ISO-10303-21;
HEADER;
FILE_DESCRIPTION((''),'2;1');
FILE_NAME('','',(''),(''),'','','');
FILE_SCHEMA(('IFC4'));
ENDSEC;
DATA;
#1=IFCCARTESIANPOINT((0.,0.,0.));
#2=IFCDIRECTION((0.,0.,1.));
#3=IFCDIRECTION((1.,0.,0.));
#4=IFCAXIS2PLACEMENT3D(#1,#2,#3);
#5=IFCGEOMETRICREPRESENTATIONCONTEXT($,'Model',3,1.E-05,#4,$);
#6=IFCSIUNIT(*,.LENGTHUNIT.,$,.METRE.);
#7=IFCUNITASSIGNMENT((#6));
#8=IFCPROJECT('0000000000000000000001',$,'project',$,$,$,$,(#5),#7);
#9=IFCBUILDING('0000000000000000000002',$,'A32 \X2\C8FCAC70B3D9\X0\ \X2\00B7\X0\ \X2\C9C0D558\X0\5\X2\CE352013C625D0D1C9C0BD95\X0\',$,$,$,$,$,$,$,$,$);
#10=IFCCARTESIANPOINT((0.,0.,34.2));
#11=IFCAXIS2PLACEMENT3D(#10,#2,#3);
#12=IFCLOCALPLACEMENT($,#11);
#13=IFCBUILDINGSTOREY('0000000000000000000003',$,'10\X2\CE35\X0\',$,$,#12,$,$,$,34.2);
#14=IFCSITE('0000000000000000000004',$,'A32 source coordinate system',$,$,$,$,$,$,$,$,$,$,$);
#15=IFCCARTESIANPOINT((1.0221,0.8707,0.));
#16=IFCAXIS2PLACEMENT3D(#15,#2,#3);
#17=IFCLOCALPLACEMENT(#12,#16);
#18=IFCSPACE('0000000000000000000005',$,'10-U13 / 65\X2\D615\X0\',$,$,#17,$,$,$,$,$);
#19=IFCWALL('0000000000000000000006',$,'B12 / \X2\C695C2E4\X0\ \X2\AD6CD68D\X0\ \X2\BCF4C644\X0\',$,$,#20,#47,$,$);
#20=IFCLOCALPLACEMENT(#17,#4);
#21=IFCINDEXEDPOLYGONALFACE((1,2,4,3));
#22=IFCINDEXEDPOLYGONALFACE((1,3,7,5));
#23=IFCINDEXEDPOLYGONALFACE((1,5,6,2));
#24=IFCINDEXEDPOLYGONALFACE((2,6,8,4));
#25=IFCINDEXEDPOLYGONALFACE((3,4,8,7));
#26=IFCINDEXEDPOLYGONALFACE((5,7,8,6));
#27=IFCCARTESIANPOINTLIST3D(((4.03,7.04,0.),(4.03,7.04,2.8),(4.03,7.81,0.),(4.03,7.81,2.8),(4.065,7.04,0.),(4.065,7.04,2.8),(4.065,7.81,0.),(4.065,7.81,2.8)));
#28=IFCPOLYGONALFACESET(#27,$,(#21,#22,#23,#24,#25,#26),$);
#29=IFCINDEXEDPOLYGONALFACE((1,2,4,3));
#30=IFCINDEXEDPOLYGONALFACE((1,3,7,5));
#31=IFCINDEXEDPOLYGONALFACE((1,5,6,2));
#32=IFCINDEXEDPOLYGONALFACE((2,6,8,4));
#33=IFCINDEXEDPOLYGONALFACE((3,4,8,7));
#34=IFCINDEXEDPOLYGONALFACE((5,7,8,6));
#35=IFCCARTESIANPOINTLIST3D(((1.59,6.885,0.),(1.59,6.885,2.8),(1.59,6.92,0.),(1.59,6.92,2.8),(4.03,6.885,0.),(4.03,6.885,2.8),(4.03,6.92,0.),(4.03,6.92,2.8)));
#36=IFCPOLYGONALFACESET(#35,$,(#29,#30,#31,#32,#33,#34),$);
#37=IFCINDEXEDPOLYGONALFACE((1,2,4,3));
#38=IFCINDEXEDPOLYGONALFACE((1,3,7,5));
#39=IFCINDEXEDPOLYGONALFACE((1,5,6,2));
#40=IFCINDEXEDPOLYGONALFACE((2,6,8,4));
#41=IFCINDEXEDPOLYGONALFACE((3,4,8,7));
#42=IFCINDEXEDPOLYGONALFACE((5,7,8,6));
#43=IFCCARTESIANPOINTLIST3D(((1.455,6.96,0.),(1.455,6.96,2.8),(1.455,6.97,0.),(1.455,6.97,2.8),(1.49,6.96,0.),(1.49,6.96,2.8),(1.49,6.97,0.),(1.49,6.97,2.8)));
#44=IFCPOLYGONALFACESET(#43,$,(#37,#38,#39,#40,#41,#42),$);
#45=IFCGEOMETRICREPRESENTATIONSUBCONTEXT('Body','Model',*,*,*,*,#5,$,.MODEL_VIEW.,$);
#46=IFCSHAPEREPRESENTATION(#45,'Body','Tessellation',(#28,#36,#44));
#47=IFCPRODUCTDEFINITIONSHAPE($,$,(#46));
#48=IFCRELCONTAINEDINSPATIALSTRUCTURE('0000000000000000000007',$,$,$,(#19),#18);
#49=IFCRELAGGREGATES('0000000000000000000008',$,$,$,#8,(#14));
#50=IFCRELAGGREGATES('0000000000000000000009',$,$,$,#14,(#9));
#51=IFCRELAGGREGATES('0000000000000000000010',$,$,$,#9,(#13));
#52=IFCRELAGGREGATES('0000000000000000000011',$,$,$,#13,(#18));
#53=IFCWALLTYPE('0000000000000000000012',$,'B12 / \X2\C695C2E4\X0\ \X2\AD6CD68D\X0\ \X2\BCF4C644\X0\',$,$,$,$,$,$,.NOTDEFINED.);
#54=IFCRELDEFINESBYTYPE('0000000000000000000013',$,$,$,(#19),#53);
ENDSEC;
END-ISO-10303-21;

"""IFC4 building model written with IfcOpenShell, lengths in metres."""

from ifc_helpers import new_model, si_unit, frame, origin, origin_with_axes, place, context, subcontext, project, spatial, polyline, outline, extrude, source, transform, mapped, type_object, type_shapes, element, save


model = new_model("IFC4")

# Units and contexts
model_context = context("Model", 3, precision=1e-05, world=origin_with_axes())
body_context = subcontext(model_context, "Body", "Model", "MODEL_VIEW")
ifc_project = project(units=[si_unit("LENGTHUNIT", "METRE")], contexts=[model_context])

# Site, building, storey, space
storey_placement = place(None, frame((0.0, 0.0, 34.2), z_axis=(0.0, 0.0, 1.0), x_axis=(1.0, 0.0, 0.0)))
space_placement = place(storey_placement, frame((1.0221, 0.8707, 0.0), z_axis=(0.0, 0.0, 1.0), x_axis=(1.0, 0.0, 0.0)))
site = spatial("IfcSite", under=ifc_project, Name="A32 source coordinate system")
building = spatial("IfcBuilding", under=site, Name="A32 주거동 · 지하5층–옥탑지붕")
storey = spatial("IfcBuildingStorey", under=building, at=storey_placement, Name="10층", Elevation=34.2)
space = spatial("IfcSpace", under=storey, at=space_placement, Name="10-U13 / 65형")

# Wall
wall_type_1 = type_object("IfcWallType", Name="B12 / 욕실 구획 보완", PredefinedType="NOTDEFINED")
shared_shape_1 = source(origin(), body_context, "Body", "SweptSolid", [
    extrude(outline(polyline([(4.065, 7.04), (4.03, 7.04), (4.03, 7.81), (4.065, 7.81), (4.065, 7.04)])), origin(), (0.0, 0.0, 1.0), 2.8),
    extrude(outline(polyline([(1.59, 6.92), (4.03, 6.92), (4.03, 6.885), (1.59, 6.885), (1.59, 6.92)])), origin(), (0.0, 0.0, 1.0), 2.8),
    extrude(outline(polyline([(1.455, 6.97), (1.49, 6.97), (1.49, 6.96), (1.455, 6.96), (1.455, 6.97)])), origin(), (0.0, 0.0, 1.0), 2.8),
])
type_shapes(wall_type_1, [shared_shape_1])
wall_1_placement = place(space_placement, origin_with_axes())
element("IfcWall", 1, at=wall_1_placement, inside=space, type_object=wall_type_1, Name="B12 / 욕실 구획 보완", context=body_context, shape_type="MappedRepresentation", body=[
    mapped(shared_shape_1, transform((0.0, 0.0, 0.0), scale=1.0)),
])

save(model, "model.ifc")
